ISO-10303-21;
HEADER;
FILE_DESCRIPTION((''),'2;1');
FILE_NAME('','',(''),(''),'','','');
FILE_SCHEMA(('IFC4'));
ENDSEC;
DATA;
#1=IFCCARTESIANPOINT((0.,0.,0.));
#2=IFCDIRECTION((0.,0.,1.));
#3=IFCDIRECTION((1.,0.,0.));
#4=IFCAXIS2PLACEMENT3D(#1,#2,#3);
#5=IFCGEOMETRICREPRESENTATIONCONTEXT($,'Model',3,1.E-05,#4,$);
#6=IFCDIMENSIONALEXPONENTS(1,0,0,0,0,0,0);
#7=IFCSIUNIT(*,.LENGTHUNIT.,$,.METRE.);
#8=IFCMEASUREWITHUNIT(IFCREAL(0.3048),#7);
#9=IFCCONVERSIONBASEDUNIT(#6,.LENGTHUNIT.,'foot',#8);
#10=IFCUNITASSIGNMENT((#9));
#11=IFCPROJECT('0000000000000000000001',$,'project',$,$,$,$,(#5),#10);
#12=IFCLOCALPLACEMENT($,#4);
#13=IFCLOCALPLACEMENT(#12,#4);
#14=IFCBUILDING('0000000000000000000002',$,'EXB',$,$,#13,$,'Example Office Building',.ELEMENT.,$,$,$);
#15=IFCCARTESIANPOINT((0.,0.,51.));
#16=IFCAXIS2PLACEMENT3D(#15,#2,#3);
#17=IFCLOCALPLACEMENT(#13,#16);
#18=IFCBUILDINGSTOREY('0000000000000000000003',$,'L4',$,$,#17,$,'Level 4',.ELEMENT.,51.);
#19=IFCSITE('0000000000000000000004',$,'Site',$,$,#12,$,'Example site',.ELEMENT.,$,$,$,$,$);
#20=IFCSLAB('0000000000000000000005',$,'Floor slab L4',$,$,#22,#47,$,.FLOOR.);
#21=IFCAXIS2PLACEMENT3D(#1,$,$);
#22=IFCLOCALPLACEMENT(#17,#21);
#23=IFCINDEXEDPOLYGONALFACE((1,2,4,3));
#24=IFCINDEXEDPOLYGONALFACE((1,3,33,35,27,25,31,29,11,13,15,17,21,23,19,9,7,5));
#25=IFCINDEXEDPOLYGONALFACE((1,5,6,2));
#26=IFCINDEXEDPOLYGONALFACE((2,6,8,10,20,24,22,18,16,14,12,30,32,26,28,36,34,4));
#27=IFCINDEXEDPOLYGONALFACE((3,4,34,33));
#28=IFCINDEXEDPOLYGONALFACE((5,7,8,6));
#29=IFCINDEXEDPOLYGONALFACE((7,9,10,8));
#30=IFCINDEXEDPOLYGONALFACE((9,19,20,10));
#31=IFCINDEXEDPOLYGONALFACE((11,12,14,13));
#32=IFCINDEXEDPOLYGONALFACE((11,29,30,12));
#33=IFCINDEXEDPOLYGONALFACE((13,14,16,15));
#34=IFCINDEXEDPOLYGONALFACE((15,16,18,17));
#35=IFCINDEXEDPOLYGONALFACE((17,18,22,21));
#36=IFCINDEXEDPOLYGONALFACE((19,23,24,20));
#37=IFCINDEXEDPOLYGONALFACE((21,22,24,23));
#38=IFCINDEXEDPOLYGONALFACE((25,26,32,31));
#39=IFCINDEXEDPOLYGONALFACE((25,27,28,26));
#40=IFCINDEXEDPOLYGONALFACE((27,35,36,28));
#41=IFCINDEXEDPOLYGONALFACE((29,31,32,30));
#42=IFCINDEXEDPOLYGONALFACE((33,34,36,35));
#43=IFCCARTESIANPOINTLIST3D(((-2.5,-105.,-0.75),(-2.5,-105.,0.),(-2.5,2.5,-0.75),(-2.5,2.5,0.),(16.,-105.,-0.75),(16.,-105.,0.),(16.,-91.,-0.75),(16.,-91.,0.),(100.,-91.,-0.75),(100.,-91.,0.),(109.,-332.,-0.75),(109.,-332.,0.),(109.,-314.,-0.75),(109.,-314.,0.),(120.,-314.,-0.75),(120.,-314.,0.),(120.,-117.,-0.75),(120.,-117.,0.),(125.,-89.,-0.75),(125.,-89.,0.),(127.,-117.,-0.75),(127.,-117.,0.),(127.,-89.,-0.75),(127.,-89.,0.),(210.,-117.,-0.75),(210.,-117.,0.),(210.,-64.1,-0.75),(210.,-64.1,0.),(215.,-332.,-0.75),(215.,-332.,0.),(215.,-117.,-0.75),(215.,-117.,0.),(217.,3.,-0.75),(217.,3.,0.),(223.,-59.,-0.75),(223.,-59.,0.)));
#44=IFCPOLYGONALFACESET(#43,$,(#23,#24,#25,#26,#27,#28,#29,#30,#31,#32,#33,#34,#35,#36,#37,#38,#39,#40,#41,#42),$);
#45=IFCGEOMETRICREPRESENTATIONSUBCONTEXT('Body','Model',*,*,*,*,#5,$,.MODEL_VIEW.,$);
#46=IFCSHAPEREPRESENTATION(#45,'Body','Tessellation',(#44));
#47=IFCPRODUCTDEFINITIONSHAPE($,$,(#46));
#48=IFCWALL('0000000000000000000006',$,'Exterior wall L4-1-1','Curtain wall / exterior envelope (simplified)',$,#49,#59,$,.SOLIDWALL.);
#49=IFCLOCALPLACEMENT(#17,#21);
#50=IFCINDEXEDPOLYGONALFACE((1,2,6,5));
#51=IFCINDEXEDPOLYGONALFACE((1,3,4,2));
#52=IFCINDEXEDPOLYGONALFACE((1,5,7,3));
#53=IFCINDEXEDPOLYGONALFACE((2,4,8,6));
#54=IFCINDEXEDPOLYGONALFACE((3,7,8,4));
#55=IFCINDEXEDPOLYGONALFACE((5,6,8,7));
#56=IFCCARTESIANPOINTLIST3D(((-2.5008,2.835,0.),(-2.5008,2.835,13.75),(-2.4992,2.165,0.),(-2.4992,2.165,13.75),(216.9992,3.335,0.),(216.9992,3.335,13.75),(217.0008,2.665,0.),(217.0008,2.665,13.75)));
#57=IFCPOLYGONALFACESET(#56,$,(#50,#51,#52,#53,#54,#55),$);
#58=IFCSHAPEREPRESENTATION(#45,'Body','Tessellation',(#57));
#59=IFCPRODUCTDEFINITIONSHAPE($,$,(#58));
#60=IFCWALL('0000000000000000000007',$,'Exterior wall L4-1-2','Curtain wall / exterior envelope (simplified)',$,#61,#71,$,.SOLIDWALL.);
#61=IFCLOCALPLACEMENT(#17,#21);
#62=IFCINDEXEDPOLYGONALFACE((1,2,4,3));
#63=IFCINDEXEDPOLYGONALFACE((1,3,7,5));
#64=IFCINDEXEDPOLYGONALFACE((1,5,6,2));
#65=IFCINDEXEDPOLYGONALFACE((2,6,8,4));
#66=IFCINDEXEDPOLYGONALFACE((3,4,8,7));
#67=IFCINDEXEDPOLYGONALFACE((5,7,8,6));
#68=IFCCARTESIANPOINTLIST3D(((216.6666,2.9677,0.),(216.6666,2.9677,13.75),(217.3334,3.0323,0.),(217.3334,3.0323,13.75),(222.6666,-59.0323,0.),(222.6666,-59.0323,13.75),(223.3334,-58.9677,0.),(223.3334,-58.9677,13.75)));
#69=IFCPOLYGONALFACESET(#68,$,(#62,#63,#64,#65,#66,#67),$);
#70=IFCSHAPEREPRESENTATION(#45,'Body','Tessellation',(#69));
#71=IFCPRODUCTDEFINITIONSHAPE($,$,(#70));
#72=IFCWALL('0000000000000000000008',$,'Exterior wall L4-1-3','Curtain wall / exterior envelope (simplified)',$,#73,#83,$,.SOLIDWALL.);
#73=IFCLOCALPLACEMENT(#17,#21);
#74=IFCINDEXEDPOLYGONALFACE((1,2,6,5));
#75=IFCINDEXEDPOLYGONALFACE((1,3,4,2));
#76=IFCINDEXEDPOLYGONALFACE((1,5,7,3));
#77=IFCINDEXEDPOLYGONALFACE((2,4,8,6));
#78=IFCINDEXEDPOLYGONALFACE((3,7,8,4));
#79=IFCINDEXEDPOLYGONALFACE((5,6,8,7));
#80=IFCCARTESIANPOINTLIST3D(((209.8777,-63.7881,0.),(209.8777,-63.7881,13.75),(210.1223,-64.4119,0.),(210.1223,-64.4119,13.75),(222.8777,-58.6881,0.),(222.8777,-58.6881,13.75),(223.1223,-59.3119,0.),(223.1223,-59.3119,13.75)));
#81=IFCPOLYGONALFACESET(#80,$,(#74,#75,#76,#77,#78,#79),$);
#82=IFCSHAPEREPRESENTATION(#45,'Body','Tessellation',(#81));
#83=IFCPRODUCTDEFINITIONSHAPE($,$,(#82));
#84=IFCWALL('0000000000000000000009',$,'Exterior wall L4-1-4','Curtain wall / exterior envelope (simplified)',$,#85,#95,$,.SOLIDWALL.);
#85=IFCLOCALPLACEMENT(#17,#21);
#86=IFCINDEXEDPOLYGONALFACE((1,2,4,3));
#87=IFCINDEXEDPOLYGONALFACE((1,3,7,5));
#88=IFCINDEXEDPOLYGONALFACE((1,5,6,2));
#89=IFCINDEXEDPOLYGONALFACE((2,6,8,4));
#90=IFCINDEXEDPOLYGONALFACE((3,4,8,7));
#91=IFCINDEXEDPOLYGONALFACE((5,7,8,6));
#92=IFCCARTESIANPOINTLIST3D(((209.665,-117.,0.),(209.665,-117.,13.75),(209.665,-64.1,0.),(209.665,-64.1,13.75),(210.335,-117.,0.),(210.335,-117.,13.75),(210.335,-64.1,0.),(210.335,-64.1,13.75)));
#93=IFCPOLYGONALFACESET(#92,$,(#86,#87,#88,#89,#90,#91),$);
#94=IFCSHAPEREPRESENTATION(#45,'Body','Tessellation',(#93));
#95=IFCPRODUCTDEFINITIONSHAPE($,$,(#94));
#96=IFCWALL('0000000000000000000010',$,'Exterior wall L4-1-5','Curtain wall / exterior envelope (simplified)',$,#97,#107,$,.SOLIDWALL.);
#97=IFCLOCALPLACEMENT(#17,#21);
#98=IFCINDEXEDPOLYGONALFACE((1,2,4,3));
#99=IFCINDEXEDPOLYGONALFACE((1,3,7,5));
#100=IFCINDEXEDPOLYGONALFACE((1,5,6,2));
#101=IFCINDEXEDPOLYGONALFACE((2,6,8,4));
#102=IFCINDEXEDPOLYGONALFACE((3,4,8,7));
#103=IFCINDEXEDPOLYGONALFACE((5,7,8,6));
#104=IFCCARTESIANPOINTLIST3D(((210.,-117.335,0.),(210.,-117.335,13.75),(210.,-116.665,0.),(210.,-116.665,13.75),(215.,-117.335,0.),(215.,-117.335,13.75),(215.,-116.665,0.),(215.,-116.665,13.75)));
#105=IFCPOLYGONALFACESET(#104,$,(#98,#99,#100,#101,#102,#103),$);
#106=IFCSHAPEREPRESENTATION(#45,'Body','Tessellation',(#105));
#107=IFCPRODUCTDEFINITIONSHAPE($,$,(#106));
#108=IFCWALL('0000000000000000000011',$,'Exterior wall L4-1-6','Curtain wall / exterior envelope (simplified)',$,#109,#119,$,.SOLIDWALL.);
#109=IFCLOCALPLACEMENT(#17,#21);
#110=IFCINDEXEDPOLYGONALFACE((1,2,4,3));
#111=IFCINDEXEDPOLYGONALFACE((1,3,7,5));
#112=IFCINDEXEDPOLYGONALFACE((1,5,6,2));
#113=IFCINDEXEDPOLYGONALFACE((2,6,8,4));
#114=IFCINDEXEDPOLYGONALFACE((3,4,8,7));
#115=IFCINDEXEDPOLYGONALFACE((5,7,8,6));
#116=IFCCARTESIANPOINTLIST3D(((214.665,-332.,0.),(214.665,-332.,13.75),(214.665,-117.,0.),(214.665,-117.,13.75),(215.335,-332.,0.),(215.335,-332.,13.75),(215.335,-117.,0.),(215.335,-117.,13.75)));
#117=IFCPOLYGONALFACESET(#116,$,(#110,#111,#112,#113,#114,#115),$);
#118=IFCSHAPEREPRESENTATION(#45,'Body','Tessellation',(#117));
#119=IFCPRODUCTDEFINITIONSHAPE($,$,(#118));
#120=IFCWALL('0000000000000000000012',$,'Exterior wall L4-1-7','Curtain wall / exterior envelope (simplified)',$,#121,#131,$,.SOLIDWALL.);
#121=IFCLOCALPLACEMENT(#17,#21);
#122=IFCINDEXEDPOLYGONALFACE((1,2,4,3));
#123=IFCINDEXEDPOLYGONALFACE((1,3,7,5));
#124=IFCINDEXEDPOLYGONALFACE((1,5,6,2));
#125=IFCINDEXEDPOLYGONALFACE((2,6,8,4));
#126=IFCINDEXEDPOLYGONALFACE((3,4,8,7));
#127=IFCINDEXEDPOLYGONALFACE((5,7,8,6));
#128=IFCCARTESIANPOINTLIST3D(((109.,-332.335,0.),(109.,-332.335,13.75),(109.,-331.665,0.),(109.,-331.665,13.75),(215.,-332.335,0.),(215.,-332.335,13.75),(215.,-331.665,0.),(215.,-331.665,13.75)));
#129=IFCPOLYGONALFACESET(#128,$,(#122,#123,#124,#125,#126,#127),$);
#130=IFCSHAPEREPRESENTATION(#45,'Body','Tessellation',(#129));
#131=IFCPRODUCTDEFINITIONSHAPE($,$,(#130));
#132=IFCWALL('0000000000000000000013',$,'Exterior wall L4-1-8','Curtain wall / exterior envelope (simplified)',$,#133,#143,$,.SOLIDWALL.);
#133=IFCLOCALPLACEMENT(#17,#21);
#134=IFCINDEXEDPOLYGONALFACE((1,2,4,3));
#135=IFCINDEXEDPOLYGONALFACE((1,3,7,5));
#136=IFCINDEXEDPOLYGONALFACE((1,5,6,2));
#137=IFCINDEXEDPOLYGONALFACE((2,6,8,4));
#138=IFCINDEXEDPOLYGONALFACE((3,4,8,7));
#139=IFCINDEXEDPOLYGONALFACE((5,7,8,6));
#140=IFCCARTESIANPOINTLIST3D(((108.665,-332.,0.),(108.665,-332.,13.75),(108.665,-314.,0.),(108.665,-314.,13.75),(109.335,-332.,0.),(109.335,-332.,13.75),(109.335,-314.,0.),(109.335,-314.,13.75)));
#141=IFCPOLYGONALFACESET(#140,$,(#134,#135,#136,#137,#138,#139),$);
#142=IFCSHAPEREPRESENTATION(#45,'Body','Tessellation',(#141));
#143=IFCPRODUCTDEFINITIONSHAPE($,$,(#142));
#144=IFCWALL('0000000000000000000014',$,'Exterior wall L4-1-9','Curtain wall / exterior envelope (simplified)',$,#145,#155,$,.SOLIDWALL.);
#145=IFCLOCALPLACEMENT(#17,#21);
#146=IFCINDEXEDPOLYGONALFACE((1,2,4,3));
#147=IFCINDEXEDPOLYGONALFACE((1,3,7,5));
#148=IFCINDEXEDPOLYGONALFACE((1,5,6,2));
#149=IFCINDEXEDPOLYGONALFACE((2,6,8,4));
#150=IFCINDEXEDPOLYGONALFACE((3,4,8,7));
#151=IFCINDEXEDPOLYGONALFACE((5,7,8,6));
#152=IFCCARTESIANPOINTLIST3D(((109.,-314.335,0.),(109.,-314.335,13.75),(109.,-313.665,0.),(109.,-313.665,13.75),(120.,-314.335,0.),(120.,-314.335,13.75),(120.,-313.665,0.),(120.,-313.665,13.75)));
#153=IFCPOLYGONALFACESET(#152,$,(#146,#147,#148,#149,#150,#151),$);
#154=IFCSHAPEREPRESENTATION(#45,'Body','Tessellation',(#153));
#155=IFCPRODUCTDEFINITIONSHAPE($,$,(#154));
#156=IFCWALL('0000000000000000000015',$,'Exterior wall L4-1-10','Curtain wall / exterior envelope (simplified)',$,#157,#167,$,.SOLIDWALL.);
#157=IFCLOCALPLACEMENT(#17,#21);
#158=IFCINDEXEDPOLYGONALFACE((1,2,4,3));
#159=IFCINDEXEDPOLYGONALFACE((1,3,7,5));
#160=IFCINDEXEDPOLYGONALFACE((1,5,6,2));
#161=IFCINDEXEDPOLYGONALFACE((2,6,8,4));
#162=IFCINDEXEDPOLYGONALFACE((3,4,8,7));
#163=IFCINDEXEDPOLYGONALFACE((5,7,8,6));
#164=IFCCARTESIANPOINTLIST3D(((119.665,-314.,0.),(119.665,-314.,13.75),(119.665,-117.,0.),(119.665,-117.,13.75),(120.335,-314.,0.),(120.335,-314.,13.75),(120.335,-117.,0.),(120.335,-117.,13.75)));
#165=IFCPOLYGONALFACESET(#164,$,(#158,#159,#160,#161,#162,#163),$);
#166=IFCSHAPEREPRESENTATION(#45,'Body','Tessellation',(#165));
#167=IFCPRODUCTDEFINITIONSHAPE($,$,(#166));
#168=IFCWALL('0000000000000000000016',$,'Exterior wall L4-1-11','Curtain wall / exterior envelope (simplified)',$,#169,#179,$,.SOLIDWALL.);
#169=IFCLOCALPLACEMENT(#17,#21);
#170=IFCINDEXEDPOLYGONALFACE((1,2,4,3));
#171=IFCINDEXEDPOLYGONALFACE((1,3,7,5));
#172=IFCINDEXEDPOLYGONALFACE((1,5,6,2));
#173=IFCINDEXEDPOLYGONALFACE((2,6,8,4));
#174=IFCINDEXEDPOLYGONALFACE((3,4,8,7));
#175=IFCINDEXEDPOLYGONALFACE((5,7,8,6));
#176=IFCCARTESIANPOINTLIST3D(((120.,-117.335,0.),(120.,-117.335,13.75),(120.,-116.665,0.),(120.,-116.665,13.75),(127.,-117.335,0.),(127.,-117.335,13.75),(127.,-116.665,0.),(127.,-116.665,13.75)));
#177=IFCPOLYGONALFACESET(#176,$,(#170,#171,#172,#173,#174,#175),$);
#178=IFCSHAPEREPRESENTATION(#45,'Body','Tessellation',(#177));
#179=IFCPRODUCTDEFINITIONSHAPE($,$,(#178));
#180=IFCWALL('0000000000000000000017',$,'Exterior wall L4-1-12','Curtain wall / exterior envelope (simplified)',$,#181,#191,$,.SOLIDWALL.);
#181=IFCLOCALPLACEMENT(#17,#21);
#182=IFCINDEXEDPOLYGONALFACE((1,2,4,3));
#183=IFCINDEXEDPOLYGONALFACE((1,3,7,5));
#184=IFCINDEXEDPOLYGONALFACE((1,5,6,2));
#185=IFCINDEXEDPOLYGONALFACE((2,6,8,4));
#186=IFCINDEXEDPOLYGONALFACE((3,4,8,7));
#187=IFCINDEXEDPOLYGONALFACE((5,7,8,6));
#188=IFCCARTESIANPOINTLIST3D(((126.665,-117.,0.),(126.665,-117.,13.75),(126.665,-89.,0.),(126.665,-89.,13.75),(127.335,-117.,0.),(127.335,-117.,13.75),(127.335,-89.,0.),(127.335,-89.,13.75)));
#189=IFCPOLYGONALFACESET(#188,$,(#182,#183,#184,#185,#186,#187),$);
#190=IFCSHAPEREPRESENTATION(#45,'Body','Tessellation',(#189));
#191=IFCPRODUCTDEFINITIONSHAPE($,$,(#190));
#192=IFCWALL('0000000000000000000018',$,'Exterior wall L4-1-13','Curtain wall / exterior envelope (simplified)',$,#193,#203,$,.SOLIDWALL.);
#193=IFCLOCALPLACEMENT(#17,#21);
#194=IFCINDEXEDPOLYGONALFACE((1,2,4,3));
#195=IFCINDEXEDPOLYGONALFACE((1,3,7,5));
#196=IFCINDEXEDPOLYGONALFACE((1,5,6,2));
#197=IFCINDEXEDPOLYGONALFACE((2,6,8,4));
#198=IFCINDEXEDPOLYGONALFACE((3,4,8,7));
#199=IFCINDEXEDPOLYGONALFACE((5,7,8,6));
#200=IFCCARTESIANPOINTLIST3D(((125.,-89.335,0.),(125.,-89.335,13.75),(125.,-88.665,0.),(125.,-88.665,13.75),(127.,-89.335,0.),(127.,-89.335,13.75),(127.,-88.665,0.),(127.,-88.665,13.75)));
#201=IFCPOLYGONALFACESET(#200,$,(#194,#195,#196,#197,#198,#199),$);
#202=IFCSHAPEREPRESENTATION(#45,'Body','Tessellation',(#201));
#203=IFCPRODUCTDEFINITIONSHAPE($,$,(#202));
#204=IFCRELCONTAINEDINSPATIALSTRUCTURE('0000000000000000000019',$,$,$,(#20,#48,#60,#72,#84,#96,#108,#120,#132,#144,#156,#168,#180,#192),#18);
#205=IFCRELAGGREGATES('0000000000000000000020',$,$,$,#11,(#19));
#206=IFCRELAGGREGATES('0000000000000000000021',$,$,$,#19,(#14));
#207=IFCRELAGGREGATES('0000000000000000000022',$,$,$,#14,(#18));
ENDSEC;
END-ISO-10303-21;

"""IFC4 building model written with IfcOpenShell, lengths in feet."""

from ifc_helpers import new_model, entity, si_unit, converted_unit, frame, frame_2d, origin, origin_with_axes, place, context, subcontext, project, spatial, polyline, rectangle, outline, extrude, element, save


model = new_model("IFC4")

# Units and contexts
model_context = context("Model", 3, precision=1e-05, world=origin_with_axes())
body_context = subcontext(model_context, "Body", "Model", "MODEL_VIEW")
ifc_project = project(units=[converted_unit("LENGTHUNIT", "foot", entity("IfcReal", 0.3048), si_unit("LENGTHUNIT", "METRE"), dimensions=[1, 0, 0, 0, 0, 0, 0])], contexts=[model_context])

# Site, building, storey
site_placement = place(None, origin_with_axes())
site = spatial("IfcSite", under=ifc_project, at=site_placement, Name="Site", LongName="Example site", CompositionType="ELEMENT")
building_placement = place(site_placement, origin_with_axes())
building = spatial("IfcBuilding", under=site, at=building_placement, Name="EXB", LongName="Example Office Building", CompositionType="ELEMENT")
storey_placement = place(building_placement, frame((0.0, 0.0, 51.0), z_axis=(0.0, 0.0, 1.0), x_axis=(1.0, 0.0, 0.0)))
storey = spatial("IfcBuildingStorey", under=building, at=storey_placement, Name="L4", LongName="Level 4", CompositionType="ELEMENT", Elevation=51.0)

# Slab
slab_placement = place(storey_placement, origin_with_axes())
element("IfcSlab", 1, at=slab_placement, inside=storey, Name="Floor slab L4", PredefinedType="FLOOR", context=body_context, shape_type="SweptSolid", body=[
    extrude(outline(polyline([(-2.5, 2.5), (217.0, 3.0), (223.0, -59.0), (210.0, -64.1), (210.0, -117.0), (215.0, -117.0), (215.0, -332.0), (109.0, -332.0), (109.0, -314.0), (120.0, -314.0), (120.0, -117.0), (127.0, -117.0), (127.0, -89.0), (125.0, -89.0), (100.0, -91.0), (16.0, -91.0), (16.0, -105.0), (-2.5, -105.0), (-2.5, 2.5)])), frame((0.0, 0.0, -0.75)), (0.0, 0.0, 1.0), 0.75),
])

# Walls
wall_1_placement = place(storey_placement, frame((-2.5, 2.5, 0.0), z_axis=(0.0, 0.0, 1.0), x_axis=(0.999997, 0.002278, 0.0)))
element("IfcWall", 2, at=wall_1_placement, inside=storey, Name="Exterior wall L4-1-1", Description="Curtain wall / exterior envelope (simplified)", PredefinedType="SOLIDWALL", context=body_context, shape_type="SweptSolid", body=[
    extrude(rectangle(XDim=219.5006, YDim=0.67, at=frame_2d((109.7503, 0.0))), origin(), (0.0, 0.0, 1.0), 13.75),
])
wall_2_placement = place(storey_placement, frame((217.0, 3.0, 0.0), z_axis=(0.0, 0.0, 1.0), x_axis=(0.096324, -0.99535, 0.0)))
element("IfcWall", 3, at=wall_2_placement, inside=storey, Name="Exterior wall L4-1-2", Description="Curtain wall / exterior envelope (simplified)", PredefinedType="SOLIDWALL", context=body_context, shape_type="SweptSolid", body=[
    extrude(rectangle(XDim=62.2896, YDim=0.67, at=frame_2d((31.1448, 0.0))), origin(), (0.0, 0.0, 1.0), 13.75),
])
wall_3_placement = place(storey_placement, frame((223.0, -59.0, 0.0), z_axis=(0.0, 0.0, 1.0), x_axis=(-0.930925, -0.365209, 0.0)))
element("IfcWall", 4, at=wall_3_placement, inside=storey, Name="Exterior wall L4-1-3", Description="Curtain wall / exterior envelope (simplified)", PredefinedType="SOLIDWALL", context=body_context, shape_type="SweptSolid", body=[
    extrude(rectangle(XDim=13.9646, YDim=0.67, at=frame_2d((6.9823, 0.0))), origin(), (0.0, 0.0, 1.0), 13.75),
])
wall_4_placement = place(storey_placement, frame((210.0, -64.1, 0.0), z_axis=(0.0, 0.0, 1.0), x_axis=(0.0, -1.0, 0.0)))
element("IfcWall", 5, at=wall_4_placement, inside=storey, Name="Exterior wall L4-1-4", Description="Curtain wall / exterior envelope (simplified)", PredefinedType="SOLIDWALL", context=body_context, shape_type="SweptSolid", body=[
    extrude(rectangle(XDim=52.9, YDim=0.67, at=frame_2d((26.45, 0.0))), origin(), (0.0, 0.0, 1.0), 13.75),
])
wall_5_placement = place(storey_placement, frame((210.0, -117.0, 0.0), z_axis=(0.0, 0.0, 1.0), x_axis=(1.0, 0.0, 0.0)))
element("IfcWall", 6, at=wall_5_placement, inside=storey, Name="Exterior wall L4-1-5", Description="Curtain wall / exterior envelope (simplified)", PredefinedType="SOLIDWALL", context=body_context, shape_type="SweptSolid", body=[
    extrude(rectangle(XDim=5.0, YDim=0.67, at=frame_2d((2.5, 0.0))), origin(), (0.0, 0.0, 1.0), 13.75),
])
wall_6_placement = place(storey_placement, frame((215.0, -117.0, 0.0), z_axis=(0.0, 0.0, 1.0), x_axis=(0.0, -1.0, 0.0)))
element("IfcWall", 7, at=wall_6_placement, inside=storey, Name="Exterior wall L4-1-6", Description="Curtain wall / exterior envelope (simplified)", PredefinedType="SOLIDWALL", context=body_context, shape_type="SweptSolid", body=[
    extrude(rectangle(XDim=215.0, YDim=0.67, at=frame_2d((107.5, 0.0))), origin(), (0.0, 0.0, 1.0), 13.75),
])
wall_7_placement = place(storey_placement, frame((215.0, -332.0, 0.0), z_axis=(0.0, 0.0, 1.0), x_axis=(-1.0, 0.0, 0.0)))
element("IfcWall", 8, at=wall_7_placement, inside=storey, Name="Exterior wall L4-1-7", Description="Curtain wall / exterior envelope (simplified)", PredefinedType="SOLIDWALL", context=body_context, shape_type="SweptSolid", body=[
    extrude(rectangle(XDim=106.0, YDim=0.67, at=frame_2d((53.0, 0.0))), origin(), (0.0, 0.0, 1.0), 13.75),
])
wall_8_placement = place(storey_placement, frame((109.0, -332.0, 0.0), z_axis=(0.0, 0.0, 1.0), x_axis=(0.0, 1.0, 0.0)))
element("IfcWall", 9, at=wall_8_placement, inside=storey, Name="Exterior wall L4-1-8", Description="Curtain wall / exterior envelope (simplified)", PredefinedType="SOLIDWALL", context=body_context, shape_type="SweptSolid", body=[
    extrude(rectangle(XDim=18.0, YDim=0.67, at=frame_2d((9.0, 0.0))), origin(), (0.0, 0.0, 1.0), 13.75),
])
wall_9_placement = place(storey_placement, frame((109.0, -314.0, 0.0), z_axis=(0.0, 0.0, 1.0), x_axis=(1.0, 0.0, 0.0)))
element("IfcWall", 10, at=wall_9_placement, inside=storey, Name="Exterior wall L4-1-9", Description="Curtain wall / exterior envelope (simplified)", PredefinedType="SOLIDWALL", context=body_context, shape_type="SweptSolid", body=[
    extrude(rectangle(XDim=11.0, YDim=0.67, at=frame_2d((5.5, 0.0))), origin(), (0.0, 0.0, 1.0), 13.75),
])
wall_10_placement = place(storey_placement, frame((120.0, -314.0, 0.0), z_axis=(0.0, 0.0, 1.0), x_axis=(0.0, 1.0, 0.0)))
element("IfcWall", 11, at=wall_10_placement, inside=storey, Name="Exterior wall L4-1-10", Description="Curtain wall / exterior envelope (simplified)", PredefinedType="SOLIDWALL", context=body_context, shape_type="SweptSolid", body=[
    extrude(rectangle(XDim=197.0, YDim=0.67, at=frame_2d((98.5, 0.0))), origin(), (0.0, 0.0, 1.0), 13.75),
])
wall_11_placement = place(storey_placement, frame((120.0, -117.0, 0.0), z_axis=(0.0, 0.0, 1.0), x_axis=(1.0, 0.0, 0.0)))
element("IfcWall", 12, at=wall_11_placement, inside=storey, Name="Exterior wall L4-1-11", Description="Curtain wall / exterior envelope (simplified)", PredefinedType="SOLIDWALL", context=body_context, shape_type="SweptSolid", body=[
    extrude(rectangle(XDim=7.0, YDim=0.67, at=frame_2d((3.5, 0.0))), origin(), (0.0, 0.0, 1.0), 13.75),
])
wall_12_placement = place(storey_placement, frame((127.0, -117.0, 0.0), z_axis=(0.0, 0.0, 1.0), x_axis=(0.0, 1.0, 0.0)))
element("IfcWall", 13, at=wall_12_placement, inside=storey, Name="Exterior wall L4-1-12", Description="Curtain wall / exterior envelope (simplified)", PredefinedType="SOLIDWALL", context=body_context, shape_type="SweptSolid", body=[
    extrude(rectangle(XDim=28.0, YDim=0.67, at=frame_2d((14.0, 0.0))), origin(), (0.0, 0.0, 1.0), 13.75),
])
wall_13_placement = place(storey_placement, frame((127.0, -89.0, 0.0), z_axis=(0.0, 0.0, 1.0), x_axis=(-1.0, 0.0, 0.0)))
element("IfcWall", 14, at=wall_13_placement, inside=storey, Name="Exterior wall L4-1-13", Description="Curtain wall / exterior envelope (simplified)", PredefinedType="SOLIDWALL", context=body_context, shape_type="SweptSolid", body=[
    extrude(rectangle(XDim=2.0, YDim=0.67, at=frame_2d((1.0, 0.0))), origin(), (0.0, 0.0, 1.0), 13.75),
])

save(model, "model.ifc")
